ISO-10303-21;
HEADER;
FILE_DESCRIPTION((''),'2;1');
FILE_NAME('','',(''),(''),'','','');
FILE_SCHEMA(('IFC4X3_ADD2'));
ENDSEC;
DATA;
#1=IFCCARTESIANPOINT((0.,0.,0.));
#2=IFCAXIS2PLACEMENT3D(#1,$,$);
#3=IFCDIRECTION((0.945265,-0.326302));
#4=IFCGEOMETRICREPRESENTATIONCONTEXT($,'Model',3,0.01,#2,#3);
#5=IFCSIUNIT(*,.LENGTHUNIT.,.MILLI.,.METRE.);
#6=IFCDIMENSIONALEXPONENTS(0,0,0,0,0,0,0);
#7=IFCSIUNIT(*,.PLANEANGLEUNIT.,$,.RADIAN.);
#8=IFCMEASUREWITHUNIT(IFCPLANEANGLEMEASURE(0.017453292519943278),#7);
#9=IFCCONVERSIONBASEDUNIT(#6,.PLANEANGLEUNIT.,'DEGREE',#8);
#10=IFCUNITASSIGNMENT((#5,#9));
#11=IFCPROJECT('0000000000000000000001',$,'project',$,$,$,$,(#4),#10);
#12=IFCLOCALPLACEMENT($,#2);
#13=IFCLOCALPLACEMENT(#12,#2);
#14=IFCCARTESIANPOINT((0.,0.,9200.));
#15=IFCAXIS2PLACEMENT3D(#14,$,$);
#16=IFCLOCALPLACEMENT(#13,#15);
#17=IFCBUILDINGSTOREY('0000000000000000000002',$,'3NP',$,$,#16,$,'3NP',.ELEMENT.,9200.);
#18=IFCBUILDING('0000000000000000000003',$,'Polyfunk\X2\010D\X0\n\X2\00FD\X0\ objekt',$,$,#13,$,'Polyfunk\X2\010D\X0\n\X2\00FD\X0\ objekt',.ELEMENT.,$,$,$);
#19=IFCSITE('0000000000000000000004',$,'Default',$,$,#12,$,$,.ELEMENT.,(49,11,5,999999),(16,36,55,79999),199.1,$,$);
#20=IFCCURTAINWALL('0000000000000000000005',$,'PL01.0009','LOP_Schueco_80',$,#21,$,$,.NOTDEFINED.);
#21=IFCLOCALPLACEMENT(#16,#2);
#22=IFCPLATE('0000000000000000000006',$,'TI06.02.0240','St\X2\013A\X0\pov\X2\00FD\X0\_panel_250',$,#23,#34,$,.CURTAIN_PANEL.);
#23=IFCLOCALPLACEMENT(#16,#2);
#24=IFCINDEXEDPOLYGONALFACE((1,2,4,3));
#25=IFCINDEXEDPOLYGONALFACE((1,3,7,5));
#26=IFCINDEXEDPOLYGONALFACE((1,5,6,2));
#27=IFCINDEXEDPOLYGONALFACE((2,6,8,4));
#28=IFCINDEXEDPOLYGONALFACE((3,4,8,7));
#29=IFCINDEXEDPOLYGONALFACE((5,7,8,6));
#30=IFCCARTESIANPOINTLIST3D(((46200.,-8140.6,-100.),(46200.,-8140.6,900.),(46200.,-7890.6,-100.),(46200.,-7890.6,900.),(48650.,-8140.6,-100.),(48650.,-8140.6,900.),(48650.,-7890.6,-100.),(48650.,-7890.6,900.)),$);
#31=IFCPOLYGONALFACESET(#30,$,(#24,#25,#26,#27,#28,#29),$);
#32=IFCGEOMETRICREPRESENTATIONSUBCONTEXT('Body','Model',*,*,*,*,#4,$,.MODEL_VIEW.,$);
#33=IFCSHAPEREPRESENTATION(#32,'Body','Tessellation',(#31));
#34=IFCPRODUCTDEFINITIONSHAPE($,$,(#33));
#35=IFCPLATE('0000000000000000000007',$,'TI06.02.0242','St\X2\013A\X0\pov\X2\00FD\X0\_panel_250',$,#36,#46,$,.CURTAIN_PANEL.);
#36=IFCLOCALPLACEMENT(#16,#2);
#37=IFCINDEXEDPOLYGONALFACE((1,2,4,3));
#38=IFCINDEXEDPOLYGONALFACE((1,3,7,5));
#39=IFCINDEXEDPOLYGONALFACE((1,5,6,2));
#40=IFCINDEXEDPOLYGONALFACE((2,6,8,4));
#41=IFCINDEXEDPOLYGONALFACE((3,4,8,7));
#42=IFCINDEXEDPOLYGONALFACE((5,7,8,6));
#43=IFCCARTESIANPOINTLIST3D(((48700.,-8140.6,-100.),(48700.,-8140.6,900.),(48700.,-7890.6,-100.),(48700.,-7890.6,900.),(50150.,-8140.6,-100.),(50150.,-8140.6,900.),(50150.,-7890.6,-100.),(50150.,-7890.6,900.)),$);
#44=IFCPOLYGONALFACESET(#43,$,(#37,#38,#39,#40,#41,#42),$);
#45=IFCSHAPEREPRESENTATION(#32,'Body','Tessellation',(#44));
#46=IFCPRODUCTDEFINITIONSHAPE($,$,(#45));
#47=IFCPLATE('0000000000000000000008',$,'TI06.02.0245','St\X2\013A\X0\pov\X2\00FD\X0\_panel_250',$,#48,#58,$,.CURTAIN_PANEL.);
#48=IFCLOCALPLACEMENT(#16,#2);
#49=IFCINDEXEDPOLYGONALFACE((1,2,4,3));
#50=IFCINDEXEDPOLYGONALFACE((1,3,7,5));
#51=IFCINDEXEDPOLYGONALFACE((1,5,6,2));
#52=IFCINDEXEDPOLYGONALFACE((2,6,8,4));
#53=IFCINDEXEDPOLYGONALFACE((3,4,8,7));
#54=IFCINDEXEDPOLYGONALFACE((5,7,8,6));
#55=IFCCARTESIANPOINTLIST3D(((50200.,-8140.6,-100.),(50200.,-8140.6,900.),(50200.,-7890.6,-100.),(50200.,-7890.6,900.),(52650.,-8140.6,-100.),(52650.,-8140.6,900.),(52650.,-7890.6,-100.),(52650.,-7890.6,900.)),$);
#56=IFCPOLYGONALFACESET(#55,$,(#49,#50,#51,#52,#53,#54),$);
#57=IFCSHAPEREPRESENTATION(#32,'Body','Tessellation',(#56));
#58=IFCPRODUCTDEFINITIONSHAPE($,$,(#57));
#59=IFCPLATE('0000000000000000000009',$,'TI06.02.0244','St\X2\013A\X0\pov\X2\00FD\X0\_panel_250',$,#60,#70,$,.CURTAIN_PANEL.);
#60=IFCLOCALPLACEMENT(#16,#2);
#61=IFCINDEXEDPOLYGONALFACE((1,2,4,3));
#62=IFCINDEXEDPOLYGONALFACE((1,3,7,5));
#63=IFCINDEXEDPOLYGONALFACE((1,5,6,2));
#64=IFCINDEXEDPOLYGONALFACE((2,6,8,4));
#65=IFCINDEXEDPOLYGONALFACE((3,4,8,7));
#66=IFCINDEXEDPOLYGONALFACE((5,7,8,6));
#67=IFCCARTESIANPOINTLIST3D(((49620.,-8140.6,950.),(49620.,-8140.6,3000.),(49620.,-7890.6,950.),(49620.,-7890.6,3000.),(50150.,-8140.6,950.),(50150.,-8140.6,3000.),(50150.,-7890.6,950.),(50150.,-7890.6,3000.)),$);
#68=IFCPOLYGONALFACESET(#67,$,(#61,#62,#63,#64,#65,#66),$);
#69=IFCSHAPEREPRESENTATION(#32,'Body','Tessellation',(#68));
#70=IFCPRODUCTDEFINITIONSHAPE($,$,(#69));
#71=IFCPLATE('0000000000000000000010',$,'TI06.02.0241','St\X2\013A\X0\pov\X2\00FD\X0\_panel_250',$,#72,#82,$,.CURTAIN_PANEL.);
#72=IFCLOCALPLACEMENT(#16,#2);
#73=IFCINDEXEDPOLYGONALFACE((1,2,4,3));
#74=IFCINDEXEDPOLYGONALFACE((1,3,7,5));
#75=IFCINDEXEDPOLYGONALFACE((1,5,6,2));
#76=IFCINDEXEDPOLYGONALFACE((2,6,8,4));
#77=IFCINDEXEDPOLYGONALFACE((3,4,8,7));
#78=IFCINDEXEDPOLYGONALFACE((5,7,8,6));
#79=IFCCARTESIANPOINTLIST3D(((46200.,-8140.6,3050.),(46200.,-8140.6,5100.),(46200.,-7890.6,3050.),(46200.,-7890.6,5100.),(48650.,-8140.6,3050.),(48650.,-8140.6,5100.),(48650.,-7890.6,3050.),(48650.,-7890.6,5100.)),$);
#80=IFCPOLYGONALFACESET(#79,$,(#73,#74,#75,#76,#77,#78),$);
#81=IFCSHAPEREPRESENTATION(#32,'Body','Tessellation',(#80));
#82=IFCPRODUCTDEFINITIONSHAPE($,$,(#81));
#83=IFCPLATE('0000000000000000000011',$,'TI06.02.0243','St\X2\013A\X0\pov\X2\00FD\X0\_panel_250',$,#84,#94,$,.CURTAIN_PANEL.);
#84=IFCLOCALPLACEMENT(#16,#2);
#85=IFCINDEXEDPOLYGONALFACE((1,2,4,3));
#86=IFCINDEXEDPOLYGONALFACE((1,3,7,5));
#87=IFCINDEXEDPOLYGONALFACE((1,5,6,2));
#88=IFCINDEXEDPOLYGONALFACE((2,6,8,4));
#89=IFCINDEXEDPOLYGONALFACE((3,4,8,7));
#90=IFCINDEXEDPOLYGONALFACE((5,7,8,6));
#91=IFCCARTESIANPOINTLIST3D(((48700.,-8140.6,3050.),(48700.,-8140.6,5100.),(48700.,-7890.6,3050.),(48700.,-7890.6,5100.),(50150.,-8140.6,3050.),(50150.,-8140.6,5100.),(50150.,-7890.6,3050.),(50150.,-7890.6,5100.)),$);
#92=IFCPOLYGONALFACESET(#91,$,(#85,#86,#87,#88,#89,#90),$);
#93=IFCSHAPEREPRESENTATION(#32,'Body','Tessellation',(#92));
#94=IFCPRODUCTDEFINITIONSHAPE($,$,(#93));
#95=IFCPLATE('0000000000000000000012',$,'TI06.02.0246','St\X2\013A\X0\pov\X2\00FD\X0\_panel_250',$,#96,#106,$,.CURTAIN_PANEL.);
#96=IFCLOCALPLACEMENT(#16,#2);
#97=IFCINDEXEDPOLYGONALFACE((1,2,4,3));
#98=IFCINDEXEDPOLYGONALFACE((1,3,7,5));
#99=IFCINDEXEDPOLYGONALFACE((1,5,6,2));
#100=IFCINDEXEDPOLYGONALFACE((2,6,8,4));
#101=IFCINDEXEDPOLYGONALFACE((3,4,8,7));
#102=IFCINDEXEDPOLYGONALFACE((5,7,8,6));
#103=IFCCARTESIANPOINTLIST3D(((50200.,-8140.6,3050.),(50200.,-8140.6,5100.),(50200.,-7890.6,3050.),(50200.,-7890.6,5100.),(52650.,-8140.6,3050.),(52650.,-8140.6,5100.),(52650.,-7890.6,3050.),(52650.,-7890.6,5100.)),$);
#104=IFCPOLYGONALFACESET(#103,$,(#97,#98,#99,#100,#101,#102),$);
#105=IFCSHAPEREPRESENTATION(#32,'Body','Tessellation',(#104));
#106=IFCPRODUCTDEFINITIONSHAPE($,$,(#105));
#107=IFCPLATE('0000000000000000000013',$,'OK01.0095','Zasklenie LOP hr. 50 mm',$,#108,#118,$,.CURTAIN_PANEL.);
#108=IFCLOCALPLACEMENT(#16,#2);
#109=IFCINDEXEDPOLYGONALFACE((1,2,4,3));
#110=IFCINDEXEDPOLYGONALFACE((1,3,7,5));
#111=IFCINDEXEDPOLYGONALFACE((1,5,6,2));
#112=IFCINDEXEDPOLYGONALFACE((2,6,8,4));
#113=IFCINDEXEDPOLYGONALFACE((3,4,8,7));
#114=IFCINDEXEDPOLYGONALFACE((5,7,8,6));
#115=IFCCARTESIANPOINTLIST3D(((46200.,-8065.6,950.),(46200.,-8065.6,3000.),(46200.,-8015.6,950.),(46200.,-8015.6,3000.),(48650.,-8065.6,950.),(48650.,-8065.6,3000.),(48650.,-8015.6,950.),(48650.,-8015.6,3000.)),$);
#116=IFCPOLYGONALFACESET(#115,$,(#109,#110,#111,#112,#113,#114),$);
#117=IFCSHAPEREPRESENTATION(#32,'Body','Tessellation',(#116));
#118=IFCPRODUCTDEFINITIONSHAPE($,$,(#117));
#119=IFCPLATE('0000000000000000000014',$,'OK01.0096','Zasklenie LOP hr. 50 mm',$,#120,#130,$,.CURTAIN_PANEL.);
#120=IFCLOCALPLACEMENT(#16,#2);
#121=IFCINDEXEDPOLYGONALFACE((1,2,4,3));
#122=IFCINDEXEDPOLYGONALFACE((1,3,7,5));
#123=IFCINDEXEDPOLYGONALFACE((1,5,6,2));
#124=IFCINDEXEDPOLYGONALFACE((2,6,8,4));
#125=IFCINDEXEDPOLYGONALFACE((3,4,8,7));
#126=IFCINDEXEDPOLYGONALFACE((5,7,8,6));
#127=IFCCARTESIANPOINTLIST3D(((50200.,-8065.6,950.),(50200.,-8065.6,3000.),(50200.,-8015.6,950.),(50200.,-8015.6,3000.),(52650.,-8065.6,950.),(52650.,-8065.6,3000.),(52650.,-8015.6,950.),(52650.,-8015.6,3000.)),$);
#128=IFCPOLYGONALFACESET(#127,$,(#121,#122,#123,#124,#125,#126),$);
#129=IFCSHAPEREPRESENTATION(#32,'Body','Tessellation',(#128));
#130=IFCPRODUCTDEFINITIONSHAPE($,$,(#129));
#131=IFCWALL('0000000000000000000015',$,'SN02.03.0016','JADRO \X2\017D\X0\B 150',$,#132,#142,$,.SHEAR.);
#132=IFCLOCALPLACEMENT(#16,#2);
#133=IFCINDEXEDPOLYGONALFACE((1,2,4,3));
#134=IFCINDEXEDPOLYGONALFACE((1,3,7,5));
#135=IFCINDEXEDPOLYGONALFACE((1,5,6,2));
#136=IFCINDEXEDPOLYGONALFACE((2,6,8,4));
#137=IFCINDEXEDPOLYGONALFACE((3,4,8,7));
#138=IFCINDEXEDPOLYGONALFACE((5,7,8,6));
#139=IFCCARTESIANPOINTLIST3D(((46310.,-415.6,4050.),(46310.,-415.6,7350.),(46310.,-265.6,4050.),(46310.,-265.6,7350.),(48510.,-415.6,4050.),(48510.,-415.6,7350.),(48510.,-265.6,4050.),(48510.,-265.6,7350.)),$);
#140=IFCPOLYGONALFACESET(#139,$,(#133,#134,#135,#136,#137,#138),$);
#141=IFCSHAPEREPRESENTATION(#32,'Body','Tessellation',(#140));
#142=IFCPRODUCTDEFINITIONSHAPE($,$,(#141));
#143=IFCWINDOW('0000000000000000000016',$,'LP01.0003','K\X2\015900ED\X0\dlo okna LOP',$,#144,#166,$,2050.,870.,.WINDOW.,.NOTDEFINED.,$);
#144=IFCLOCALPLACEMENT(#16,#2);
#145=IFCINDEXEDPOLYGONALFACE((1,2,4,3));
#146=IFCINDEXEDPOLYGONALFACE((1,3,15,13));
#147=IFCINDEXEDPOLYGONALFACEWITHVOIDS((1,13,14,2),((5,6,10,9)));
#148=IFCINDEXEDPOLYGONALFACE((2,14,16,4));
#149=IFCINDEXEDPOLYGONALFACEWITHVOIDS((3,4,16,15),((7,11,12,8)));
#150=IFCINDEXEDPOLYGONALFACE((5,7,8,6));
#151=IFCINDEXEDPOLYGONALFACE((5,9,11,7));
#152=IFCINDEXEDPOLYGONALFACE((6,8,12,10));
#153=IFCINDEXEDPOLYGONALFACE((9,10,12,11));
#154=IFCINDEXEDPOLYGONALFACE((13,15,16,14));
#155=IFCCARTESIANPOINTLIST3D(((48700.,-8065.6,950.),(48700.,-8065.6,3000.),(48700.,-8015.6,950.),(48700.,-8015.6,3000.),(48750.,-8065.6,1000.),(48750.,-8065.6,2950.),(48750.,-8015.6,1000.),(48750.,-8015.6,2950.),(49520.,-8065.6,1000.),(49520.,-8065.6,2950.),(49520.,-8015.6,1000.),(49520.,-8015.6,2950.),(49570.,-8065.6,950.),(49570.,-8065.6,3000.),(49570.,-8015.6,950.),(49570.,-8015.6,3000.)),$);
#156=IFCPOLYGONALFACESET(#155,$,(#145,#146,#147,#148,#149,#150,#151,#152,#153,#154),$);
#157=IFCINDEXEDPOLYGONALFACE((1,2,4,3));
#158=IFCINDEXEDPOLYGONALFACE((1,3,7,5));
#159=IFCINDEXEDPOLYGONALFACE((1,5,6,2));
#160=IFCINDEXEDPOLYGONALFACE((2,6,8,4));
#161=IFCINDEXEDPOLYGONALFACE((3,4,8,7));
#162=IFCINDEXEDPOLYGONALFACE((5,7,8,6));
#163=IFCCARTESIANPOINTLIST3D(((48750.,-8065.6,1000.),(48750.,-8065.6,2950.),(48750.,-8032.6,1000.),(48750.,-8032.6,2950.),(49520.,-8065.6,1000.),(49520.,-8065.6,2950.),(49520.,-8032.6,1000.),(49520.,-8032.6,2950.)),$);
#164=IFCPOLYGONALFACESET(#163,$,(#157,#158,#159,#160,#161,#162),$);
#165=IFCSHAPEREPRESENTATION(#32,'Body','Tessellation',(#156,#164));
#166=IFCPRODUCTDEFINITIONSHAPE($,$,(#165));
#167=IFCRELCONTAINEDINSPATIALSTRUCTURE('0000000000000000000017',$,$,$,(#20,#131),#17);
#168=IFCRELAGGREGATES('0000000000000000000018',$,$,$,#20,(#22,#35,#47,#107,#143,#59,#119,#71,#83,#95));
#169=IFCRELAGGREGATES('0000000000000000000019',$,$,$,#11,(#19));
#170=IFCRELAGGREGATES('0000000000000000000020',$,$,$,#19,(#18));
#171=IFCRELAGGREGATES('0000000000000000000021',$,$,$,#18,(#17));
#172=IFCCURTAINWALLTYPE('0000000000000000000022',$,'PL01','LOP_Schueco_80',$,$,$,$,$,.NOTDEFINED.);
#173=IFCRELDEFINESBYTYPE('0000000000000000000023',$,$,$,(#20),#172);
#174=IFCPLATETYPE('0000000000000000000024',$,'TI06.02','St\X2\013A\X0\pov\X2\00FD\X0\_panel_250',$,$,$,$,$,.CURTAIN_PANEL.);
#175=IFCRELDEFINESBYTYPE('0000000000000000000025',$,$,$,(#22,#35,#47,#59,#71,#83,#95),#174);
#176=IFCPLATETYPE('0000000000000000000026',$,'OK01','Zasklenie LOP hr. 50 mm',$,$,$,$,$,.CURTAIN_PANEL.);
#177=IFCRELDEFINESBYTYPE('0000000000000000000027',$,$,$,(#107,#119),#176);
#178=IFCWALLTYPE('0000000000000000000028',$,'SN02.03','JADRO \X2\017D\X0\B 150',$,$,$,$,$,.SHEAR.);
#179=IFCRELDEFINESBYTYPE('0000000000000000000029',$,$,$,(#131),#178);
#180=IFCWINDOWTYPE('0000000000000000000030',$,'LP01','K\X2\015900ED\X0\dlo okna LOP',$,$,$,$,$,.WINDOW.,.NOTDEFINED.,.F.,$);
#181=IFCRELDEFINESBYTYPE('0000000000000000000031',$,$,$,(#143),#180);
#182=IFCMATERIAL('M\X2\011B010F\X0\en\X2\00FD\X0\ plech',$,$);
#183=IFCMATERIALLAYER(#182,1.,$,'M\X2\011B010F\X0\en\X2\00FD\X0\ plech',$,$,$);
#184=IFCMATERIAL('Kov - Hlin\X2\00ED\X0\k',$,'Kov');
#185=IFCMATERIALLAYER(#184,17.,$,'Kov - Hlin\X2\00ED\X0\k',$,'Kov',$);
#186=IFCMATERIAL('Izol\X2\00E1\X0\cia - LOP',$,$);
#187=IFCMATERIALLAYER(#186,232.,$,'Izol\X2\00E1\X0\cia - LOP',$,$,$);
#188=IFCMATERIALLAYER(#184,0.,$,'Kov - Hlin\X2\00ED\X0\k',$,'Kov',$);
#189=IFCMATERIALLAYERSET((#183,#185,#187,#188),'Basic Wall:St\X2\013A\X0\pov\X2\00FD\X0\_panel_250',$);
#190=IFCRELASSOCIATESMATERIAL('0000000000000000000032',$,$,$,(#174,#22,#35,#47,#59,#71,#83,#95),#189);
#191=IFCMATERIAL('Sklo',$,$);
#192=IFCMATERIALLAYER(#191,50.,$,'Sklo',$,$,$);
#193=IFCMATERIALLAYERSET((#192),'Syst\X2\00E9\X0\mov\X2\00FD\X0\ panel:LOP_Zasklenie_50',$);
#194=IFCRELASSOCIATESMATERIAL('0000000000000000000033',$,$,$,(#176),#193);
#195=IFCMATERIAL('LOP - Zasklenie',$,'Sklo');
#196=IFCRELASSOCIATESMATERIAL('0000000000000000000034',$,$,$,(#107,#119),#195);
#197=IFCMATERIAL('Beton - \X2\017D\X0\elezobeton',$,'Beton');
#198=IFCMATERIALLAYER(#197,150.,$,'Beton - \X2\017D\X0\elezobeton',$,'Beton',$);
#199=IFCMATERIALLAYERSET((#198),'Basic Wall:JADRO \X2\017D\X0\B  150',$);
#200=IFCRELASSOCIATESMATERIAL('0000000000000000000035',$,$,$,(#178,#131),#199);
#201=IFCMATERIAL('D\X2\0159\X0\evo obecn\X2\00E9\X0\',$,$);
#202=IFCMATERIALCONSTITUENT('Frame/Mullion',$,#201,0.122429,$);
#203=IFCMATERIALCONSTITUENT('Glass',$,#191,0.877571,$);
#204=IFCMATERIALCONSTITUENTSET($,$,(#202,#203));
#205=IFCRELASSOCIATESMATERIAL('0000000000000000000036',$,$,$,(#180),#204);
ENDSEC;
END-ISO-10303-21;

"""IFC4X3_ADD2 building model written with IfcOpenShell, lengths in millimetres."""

from ifc_helpers import new_model, entity, si_unit, converted_unit, direction, frame, frame_2d, origin, origin_2d_with_axis, place, context, subcontext, project, spatial, polyline, rectangle, outline, extrude, clip, bounded_halfspace, source, transform, mapped, material, layer, layer_set, layer_usage, constituent, constituent_set, type_object, type_shapes, element, aggregate, save


model = new_model("IFC4X3_ADD2")

# Units and contexts
model_context = context("Model", 3, precision=0.01, world=origin(), true_north=direction((0.945265, -0.326302)))
body_context = subcontext(model_context, "Body", "Model", "MODEL_VIEW")
ifc_project = project(units=[si_unit("LENGTHUNIT", "METRE", prefix="MILLI"), converted_unit("PLANEANGLEUNIT", "DEGREE", entity("IfcPlaneAngleMeasure", 0.017453292519943278), si_unit("PLANEANGLEUNIT", "RADIAN"), dimensions=[0, 0, 0, 0, 0, 0, 0])], contexts=[model_context])

# Site, building, storey
site_placement = place(None, origin())
site = spatial("IfcSite", under=ifc_project, at=site_placement, Name="Default", CompositionType="ELEMENT", RefLatitude=(49, 11, 5, 999999), RefLongitude=(16, 36, 55, 79999), RefElevation=199.1)
building_placement = place(site_placement, origin())
building = spatial("IfcBuilding", under=site, at=building_placement, Name="Polyfunkčný objekt", LongName="Polyfunkčný objekt", CompositionType="ELEMENT")
storey_placement = place(building_placement, frame((0.0, 0.0, 9200.0)))
storey = spatial("IfcBuildingStorey", under=building, at=storey_placement, Name="3NP", LongName="3NP", CompositionType="ELEMENT", Elevation=9200.0)

# Curtain wall, plates
curtain_wall_type = type_object("IfcCurtainWallType", Name="PL01", Description="LOP_Schueco_80", PredefinedType="NOTDEFINED")
curtain_wall_placement = place(storey_placement, frame((0.0, 0.0, -9200.0)))
curtain_wall = element("IfcCurtainWall", 1, at=curtain_wall_placement, inside=storey, type_object=curtain_wall_type, Name="PL01.0009", Description="LOP_Schueco_80", PredefinedType="NOTDEFINED")
ifc_material_1 = material(Name="Měďený plech")
ifc_layer_1 = layer(ifc_material_1, 1.0, Name="Měďený plech")
ifc_material_2 = material(Name="Kov - Hliník", Category="Kov")
ifc_layer_2 = layer(ifc_material_2, 17.0, Name="Kov - Hliník", Category="Kov")
ifc_material_3 = material(Name="Izolácia - LOP")
ifc_layer_3 = layer(ifc_material_3, 232.0, Name="Izolácia - LOP")
ifc_layer_4 = layer(ifc_material_2, 0.0, Name="Kov - Hliník", Category="Kov")
ifc_layer_set_1 = layer_set([ifc_layer_1, ifc_layer_2, ifc_layer_3, ifc_layer_4], Name="Basic Wall:Stĺpový_panel_250")
ifc_layer_usage_1 = layer_usage(ifc_layer_set_1, "AXIS2", "POSITIVE", -125.0)
plate_type_1 = type_object("IfcPlateType", Name="TI06.02", Description="Stĺpový_panel_250", PredefinedType="CURTAIN_PANEL", material=ifc_layer_set_1)
plate_1_placement = place(storey_placement, frame((46200.0, -8015.6, -100.0)))
plate_1 = element("IfcPlate", 2, at=plate_1_placement, type_object=plate_type_1, material=ifc_layer_usage_1, Name="TI06.02.0240", Description="Stĺpový_panel_250", PredefinedType="CURTAIN_PANEL", context=body_context, shape_type="SweptSolid", body=[
    extrude(rectangle(XDim=250.0, YDim=2450.0, at=frame_2d((0.0, 0.0), x_axis=(1.0, 0.0))), frame((1225.0, 0.0, 0.0), z_axis=(0.0, 0.0, 1.0), x_axis=(0.0, 1.0, 0.0)), (0.0, 0.0, 1.0), 1000.0),
])
ifc_layer_usage_2 = layer_usage(ifc_layer_set_1, "AXIS2", "POSITIVE", -125.0)
plate_2_placement = place(storey_placement, frame((48700.0, -8015.6, -100.0)))
plate_2 = element("IfcPlate", 3, at=plate_2_placement, type_object=plate_type_1, material=ifc_layer_usage_2, Name="TI06.02.0242", Description="Stĺpový_panel_250", PredefinedType="CURTAIN_PANEL", context=body_context, shape_type="SweptSolid", body=[
    extrude(rectangle(XDim=250.0, YDim=1450.0, at=frame_2d((0.0, 0.0), x_axis=(1.0, 0.0))), frame((725.0, 0.0, 0.0), z_axis=(0.0, 0.0, 1.0), x_axis=(0.0, 1.0, 0.0)), (0.0, 0.0, 1.0), 1000.0),
])
ifc_layer_usage_3 = layer_usage(ifc_layer_set_1, "AXIS2", "POSITIVE", -125.0)
plate_3_placement = place(storey_placement, frame((50200.0, -8015.6, -100.0)))
plate_3 = element("IfcPlate", 4, at=plate_3_placement, type_object=plate_type_1, material=ifc_layer_usage_3, Name="TI06.02.0245", Description="Stĺpový_panel_250", PredefinedType="CURTAIN_PANEL", context=body_context, shape_type="SweptSolid", body=[
    extrude(rectangle(XDim=250.0, YDim=2450.0, at=origin_2d_with_axis()), frame((1225.0, 0.0, 0.0), z_axis=(0.0, 0.0, 1.0), x_axis=(0.0, 1.0, 0.0)), (0.0, 0.0, 1.0), 1000.0),
])
ifc_layer_usage_4 = layer_usage(ifc_layer_set_1, "AXIS2", "POSITIVE", -125.0)
plate_4_placement = place(storey_placement, frame((49620.0, -8015.6, 950.0)))
plate_4 = element("IfcPlate", 5, at=plate_4_placement, type_object=plate_type_1, material=ifc_layer_usage_4, Name="TI06.02.0244", Description="Stĺpový_panel_250", PredefinedType="CURTAIN_PANEL", context=body_context, shape_type="SweptSolid", body=[
    extrude(rectangle(XDim=250.0, YDim=530.0, at=origin_2d_with_axis()), frame((265.0, 0.0, 0.0), z_axis=(0.0, 0.0, 1.0), x_axis=(0.0, 1.0, 0.0)), (0.0, 0.0, 1.0), 2050.0),
])
ifc_layer_usage_5 = layer_usage(ifc_layer_set_1, "AXIS2", "POSITIVE", -125.0)
plate_5_placement = place(storey_placement, frame((46200.0, -8015.6, 3050.0)))
plate_5 = element("IfcPlate", 6, at=plate_5_placement, type_object=plate_type_1, material=ifc_layer_usage_5, Name="TI06.02.0241", Description="Stĺpový_panel_250", PredefinedType="CURTAIN_PANEL", context=body_context, shape_type="SweptSolid", body=[
    extrude(rectangle(XDim=250.0, YDim=2450.0, at=frame_2d((0.0, 0.0), x_axis=(1.0, 0.0))), frame((1225.0, 0.0, 0.0), z_axis=(0.0, 0.0, 1.0), x_axis=(0.0, 1.0, 0.0)), (0.0, 0.0, 1.0), 2050.0),
])
ifc_layer_usage_6 = layer_usage(ifc_layer_set_1, "AXIS2", "POSITIVE", -125.0)
plate_6_placement = place(storey_placement, frame((48700.0, -8015.6, 3050.0)))
plate_6 = element("IfcPlate", 7, at=plate_6_placement, type_object=plate_type_1, material=ifc_layer_usage_6, Name="TI06.02.0243", Description="Stĺpový_panel_250", PredefinedType="CURTAIN_PANEL", context=body_context, shape_type="SweptSolid", body=[
    extrude(rectangle(XDim=250.0, YDim=1450.0, at=frame_2d((0.0, 0.0), x_axis=(1.0, 0.0))), frame((725.0, 0.0, 0.0), z_axis=(0.0, 0.0, 1.0), x_axis=(0.0, 1.0, 0.0)), (0.0, 0.0, 1.0), 2050.0),
])
ifc_layer_usage_7 = layer_usage(ifc_layer_set_1, "AXIS2", "POSITIVE", -125.0)
plate_7_placement = place(storey_placement, frame((50200.0, -8015.6, 3050.0)))
plate_7 = element("IfcPlate", 8, at=plate_7_placement, type_object=plate_type_1, material=ifc_layer_usage_7, Name="TI06.02.0246", Description="Stĺpový_panel_250", PredefinedType="CURTAIN_PANEL", context=body_context, shape_type="SweptSolid", body=[
    extrude(rectangle(XDim=250.0, YDim=2450.0, at=origin_2d_with_axis()), frame((1225.0, 0.0, 0.0), z_axis=(0.0, 0.0, 1.0), x_axis=(0.0, 1.0, 0.0)), (0.0, 0.0, 1.0), 2050.0),
])
ifc_material_4 = material(Name="LOP - Zasklenie", Category="Sklo")
ifc_material_5 = material(Name="Sklo")
ifc_layer_5 = layer(ifc_material_5, 50.0, Name="Sklo")
ifc_layer_set_2 = layer_set([ifc_layer_5], Name="Systémový panel:LOP_Zasklenie_50")
plate_type_2 = type_object("IfcPlateType", Name="OK01", Description="Zasklenie LOP hr. 50 mm", PredefinedType="CURTAIN_PANEL", material=ifc_layer_set_2)
shared_shape_1 = source(origin(), body_context, "Body", "SweptSolid", [
    extrude(rectangle(XDim=50.0, YDim=2450.0, at=origin_2d_with_axis()), frame((0.0, -25.0, 0.0), z_axis=(0.0, 0.0, 1.0), x_axis=(0.0, 1.0, 0.0)), (0.0, 0.0, 1.0), 2050.0),
])
type_shapes(plate_type_2, [shared_shape_1])
plate_8_placement = place(curtain_wall_placement, frame((47425.0, -8015.6, 10150.0)))
plate_8 = element("IfcPlate", 9, at=plate_8_placement, type_object=plate_type_2, material=ifc_material_4, Name="OK01.0095", Description="Zasklenie LOP hr. 50 mm", PredefinedType="CURTAIN_PANEL", context=body_context, shape_type="MappedRepresentation", body=[
    mapped(shared_shape_1, transform((0.0, 0.0, 0.0), scale=1.0)),
])
plate_9_placement = place(curtain_wall_placement, frame((51425.0, -8015.6, 10150.0)))
plate_9 = element("IfcPlate", 10, at=plate_9_placement, type_object=plate_type_2, material=ifc_material_4, Name="OK01.0096", Description="Zasklenie LOP hr. 50 mm", PredefinedType="CURTAIN_PANEL", context=body_context, shape_type="MappedRepresentation", body=[
    mapped(shared_shape_1, transform((0.0, 0.0, 0.0), scale=1.0)),
])

# Wall
ifc_material_6 = material(Name="Beton - Železobeton", Category="Beton")
ifc_layer_6 = layer(ifc_material_6, 150.0, Name="Beton - Železobeton", Category="Beton")
ifc_layer_set_3 = layer_set([ifc_layer_6], Name="Basic Wall:JADRO ŽB  150")
wall_type_1 = type_object("IfcWallType", Name="SN02.03", Description="JADRO ŽB 150", PredefinedType="SHEAR", material=ifc_layer_set_3)
wall_1_placement = place(storey_placement, frame((46310.0, -340.6, 4050.0)))
element("IfcWall", 11, at=wall_1_placement, inside=storey, type_object=wall_type_1, material=ifc_layer_set_3, Name="SN02.03.0016", Description="JADRO ŽB 150", PredefinedType="SHEAR", context=body_context, shape_type="Clipping", body=[
    clip(extrude(rectangle(XDim=2200.0, YDim=150.0, at=frame_2d((1100.0, 0.0), x_axis=(-1.0, 0.0))), origin(), (0.0, 0.0, 1.0), 3300.0), bounded_halfspace(frame((2200.0, -75.0, 0.0), z_axis=(0.0, 0.0, 1.0), x_axis=(-1.0, 0.0, 0.0)), True, frame((2200.0, -75.0, 0.0)), polyline([(0.0, 0.0), (0.0, 150.0), (-2200.0, 150.0), (-2200.0, 0.0), (-150.0, 0.0), (0.0, 0.0)]))),
])

# Window
ifc_material_7 = material(Name="Dřevo obecné")
ifc_constituent_1 = constituent(ifc_material_7, Name="Frame/Mullion", fraction=0.122429)
ifc_constituent_2 = constituent(ifc_material_5, Name="Glass", fraction=0.877571)
ifc_constituent_set = constituent_set(constituents=[ifc_constituent_1, ifc_constituent_2])
window_type = type_object("IfcWindowType", Name="LP01", Description="Křídlo okna LOP", ParameterTakesPrecedence=False, PartitioningType="NOTDEFINED", PredefinedType="WINDOW", material=ifc_constituent_set)
shared_shape_2 = source(origin(), body_context, "Body", "SweptSolid", [
    extrude(outline(polyline([(-1025.0, -435.0), (1025.0, -435.0), (1025.0, 435.0), (-1025.0, 435.0), (-1025.0, -435.0)]), holes=[polyline([(-975.0, -385.0), (-975.0, 385.0), (975.0, 385.0), (975.0, -385.0), (-975.0, -385.0)])]), frame((0.0, 50.0, 1025.0), z_axis=(0.0, -1.0, 0.0), x_axis=(0.0, 0.0, -1.0)), (0.0, 0.0, 1.0), 50.0),
    extrude(rectangle(XDim=770.0, YDim=33.0, at=frame_2d((0.0, 0.0), x_axis=(1.0, 0.0))), frame((0.0, 33.5, 50.0), z_axis=(0.0, 0.0, 1.0), x_axis=(-1.0, 0.0, 0.0)), (0.0, 0.0, 1.0), 1950.0),
])
type_shapes(window_type, [shared_shape_2])
window_placement = place(curtain_wall_placement, frame((49135.0, -8015.6, 10150.0), z_axis=(0.0, 0.0, 1.0), x_axis=(-1.0, 0.0, 0.0)))
window = element("IfcWindow", 12, at=window_placement, type_object=window_type, Name="LP01.0003", Description="Křídlo okna LOP", OverallHeight=2050.0, OverallWidth=870.0, PartitioningType="NOTDEFINED", PredefinedType="WINDOW", context=body_context, shape_type="MappedRepresentation", body=[
    mapped(shared_shape_2, transform((0.0, 0.0, 0.0), scale=1.0)),
])
aggregate(curtain_wall, [plate_1, plate_2, plate_3, plate_8, window, plate_4, plate_9, plate_5, plate_6, plate_7])

save(model, "model.ifc")
